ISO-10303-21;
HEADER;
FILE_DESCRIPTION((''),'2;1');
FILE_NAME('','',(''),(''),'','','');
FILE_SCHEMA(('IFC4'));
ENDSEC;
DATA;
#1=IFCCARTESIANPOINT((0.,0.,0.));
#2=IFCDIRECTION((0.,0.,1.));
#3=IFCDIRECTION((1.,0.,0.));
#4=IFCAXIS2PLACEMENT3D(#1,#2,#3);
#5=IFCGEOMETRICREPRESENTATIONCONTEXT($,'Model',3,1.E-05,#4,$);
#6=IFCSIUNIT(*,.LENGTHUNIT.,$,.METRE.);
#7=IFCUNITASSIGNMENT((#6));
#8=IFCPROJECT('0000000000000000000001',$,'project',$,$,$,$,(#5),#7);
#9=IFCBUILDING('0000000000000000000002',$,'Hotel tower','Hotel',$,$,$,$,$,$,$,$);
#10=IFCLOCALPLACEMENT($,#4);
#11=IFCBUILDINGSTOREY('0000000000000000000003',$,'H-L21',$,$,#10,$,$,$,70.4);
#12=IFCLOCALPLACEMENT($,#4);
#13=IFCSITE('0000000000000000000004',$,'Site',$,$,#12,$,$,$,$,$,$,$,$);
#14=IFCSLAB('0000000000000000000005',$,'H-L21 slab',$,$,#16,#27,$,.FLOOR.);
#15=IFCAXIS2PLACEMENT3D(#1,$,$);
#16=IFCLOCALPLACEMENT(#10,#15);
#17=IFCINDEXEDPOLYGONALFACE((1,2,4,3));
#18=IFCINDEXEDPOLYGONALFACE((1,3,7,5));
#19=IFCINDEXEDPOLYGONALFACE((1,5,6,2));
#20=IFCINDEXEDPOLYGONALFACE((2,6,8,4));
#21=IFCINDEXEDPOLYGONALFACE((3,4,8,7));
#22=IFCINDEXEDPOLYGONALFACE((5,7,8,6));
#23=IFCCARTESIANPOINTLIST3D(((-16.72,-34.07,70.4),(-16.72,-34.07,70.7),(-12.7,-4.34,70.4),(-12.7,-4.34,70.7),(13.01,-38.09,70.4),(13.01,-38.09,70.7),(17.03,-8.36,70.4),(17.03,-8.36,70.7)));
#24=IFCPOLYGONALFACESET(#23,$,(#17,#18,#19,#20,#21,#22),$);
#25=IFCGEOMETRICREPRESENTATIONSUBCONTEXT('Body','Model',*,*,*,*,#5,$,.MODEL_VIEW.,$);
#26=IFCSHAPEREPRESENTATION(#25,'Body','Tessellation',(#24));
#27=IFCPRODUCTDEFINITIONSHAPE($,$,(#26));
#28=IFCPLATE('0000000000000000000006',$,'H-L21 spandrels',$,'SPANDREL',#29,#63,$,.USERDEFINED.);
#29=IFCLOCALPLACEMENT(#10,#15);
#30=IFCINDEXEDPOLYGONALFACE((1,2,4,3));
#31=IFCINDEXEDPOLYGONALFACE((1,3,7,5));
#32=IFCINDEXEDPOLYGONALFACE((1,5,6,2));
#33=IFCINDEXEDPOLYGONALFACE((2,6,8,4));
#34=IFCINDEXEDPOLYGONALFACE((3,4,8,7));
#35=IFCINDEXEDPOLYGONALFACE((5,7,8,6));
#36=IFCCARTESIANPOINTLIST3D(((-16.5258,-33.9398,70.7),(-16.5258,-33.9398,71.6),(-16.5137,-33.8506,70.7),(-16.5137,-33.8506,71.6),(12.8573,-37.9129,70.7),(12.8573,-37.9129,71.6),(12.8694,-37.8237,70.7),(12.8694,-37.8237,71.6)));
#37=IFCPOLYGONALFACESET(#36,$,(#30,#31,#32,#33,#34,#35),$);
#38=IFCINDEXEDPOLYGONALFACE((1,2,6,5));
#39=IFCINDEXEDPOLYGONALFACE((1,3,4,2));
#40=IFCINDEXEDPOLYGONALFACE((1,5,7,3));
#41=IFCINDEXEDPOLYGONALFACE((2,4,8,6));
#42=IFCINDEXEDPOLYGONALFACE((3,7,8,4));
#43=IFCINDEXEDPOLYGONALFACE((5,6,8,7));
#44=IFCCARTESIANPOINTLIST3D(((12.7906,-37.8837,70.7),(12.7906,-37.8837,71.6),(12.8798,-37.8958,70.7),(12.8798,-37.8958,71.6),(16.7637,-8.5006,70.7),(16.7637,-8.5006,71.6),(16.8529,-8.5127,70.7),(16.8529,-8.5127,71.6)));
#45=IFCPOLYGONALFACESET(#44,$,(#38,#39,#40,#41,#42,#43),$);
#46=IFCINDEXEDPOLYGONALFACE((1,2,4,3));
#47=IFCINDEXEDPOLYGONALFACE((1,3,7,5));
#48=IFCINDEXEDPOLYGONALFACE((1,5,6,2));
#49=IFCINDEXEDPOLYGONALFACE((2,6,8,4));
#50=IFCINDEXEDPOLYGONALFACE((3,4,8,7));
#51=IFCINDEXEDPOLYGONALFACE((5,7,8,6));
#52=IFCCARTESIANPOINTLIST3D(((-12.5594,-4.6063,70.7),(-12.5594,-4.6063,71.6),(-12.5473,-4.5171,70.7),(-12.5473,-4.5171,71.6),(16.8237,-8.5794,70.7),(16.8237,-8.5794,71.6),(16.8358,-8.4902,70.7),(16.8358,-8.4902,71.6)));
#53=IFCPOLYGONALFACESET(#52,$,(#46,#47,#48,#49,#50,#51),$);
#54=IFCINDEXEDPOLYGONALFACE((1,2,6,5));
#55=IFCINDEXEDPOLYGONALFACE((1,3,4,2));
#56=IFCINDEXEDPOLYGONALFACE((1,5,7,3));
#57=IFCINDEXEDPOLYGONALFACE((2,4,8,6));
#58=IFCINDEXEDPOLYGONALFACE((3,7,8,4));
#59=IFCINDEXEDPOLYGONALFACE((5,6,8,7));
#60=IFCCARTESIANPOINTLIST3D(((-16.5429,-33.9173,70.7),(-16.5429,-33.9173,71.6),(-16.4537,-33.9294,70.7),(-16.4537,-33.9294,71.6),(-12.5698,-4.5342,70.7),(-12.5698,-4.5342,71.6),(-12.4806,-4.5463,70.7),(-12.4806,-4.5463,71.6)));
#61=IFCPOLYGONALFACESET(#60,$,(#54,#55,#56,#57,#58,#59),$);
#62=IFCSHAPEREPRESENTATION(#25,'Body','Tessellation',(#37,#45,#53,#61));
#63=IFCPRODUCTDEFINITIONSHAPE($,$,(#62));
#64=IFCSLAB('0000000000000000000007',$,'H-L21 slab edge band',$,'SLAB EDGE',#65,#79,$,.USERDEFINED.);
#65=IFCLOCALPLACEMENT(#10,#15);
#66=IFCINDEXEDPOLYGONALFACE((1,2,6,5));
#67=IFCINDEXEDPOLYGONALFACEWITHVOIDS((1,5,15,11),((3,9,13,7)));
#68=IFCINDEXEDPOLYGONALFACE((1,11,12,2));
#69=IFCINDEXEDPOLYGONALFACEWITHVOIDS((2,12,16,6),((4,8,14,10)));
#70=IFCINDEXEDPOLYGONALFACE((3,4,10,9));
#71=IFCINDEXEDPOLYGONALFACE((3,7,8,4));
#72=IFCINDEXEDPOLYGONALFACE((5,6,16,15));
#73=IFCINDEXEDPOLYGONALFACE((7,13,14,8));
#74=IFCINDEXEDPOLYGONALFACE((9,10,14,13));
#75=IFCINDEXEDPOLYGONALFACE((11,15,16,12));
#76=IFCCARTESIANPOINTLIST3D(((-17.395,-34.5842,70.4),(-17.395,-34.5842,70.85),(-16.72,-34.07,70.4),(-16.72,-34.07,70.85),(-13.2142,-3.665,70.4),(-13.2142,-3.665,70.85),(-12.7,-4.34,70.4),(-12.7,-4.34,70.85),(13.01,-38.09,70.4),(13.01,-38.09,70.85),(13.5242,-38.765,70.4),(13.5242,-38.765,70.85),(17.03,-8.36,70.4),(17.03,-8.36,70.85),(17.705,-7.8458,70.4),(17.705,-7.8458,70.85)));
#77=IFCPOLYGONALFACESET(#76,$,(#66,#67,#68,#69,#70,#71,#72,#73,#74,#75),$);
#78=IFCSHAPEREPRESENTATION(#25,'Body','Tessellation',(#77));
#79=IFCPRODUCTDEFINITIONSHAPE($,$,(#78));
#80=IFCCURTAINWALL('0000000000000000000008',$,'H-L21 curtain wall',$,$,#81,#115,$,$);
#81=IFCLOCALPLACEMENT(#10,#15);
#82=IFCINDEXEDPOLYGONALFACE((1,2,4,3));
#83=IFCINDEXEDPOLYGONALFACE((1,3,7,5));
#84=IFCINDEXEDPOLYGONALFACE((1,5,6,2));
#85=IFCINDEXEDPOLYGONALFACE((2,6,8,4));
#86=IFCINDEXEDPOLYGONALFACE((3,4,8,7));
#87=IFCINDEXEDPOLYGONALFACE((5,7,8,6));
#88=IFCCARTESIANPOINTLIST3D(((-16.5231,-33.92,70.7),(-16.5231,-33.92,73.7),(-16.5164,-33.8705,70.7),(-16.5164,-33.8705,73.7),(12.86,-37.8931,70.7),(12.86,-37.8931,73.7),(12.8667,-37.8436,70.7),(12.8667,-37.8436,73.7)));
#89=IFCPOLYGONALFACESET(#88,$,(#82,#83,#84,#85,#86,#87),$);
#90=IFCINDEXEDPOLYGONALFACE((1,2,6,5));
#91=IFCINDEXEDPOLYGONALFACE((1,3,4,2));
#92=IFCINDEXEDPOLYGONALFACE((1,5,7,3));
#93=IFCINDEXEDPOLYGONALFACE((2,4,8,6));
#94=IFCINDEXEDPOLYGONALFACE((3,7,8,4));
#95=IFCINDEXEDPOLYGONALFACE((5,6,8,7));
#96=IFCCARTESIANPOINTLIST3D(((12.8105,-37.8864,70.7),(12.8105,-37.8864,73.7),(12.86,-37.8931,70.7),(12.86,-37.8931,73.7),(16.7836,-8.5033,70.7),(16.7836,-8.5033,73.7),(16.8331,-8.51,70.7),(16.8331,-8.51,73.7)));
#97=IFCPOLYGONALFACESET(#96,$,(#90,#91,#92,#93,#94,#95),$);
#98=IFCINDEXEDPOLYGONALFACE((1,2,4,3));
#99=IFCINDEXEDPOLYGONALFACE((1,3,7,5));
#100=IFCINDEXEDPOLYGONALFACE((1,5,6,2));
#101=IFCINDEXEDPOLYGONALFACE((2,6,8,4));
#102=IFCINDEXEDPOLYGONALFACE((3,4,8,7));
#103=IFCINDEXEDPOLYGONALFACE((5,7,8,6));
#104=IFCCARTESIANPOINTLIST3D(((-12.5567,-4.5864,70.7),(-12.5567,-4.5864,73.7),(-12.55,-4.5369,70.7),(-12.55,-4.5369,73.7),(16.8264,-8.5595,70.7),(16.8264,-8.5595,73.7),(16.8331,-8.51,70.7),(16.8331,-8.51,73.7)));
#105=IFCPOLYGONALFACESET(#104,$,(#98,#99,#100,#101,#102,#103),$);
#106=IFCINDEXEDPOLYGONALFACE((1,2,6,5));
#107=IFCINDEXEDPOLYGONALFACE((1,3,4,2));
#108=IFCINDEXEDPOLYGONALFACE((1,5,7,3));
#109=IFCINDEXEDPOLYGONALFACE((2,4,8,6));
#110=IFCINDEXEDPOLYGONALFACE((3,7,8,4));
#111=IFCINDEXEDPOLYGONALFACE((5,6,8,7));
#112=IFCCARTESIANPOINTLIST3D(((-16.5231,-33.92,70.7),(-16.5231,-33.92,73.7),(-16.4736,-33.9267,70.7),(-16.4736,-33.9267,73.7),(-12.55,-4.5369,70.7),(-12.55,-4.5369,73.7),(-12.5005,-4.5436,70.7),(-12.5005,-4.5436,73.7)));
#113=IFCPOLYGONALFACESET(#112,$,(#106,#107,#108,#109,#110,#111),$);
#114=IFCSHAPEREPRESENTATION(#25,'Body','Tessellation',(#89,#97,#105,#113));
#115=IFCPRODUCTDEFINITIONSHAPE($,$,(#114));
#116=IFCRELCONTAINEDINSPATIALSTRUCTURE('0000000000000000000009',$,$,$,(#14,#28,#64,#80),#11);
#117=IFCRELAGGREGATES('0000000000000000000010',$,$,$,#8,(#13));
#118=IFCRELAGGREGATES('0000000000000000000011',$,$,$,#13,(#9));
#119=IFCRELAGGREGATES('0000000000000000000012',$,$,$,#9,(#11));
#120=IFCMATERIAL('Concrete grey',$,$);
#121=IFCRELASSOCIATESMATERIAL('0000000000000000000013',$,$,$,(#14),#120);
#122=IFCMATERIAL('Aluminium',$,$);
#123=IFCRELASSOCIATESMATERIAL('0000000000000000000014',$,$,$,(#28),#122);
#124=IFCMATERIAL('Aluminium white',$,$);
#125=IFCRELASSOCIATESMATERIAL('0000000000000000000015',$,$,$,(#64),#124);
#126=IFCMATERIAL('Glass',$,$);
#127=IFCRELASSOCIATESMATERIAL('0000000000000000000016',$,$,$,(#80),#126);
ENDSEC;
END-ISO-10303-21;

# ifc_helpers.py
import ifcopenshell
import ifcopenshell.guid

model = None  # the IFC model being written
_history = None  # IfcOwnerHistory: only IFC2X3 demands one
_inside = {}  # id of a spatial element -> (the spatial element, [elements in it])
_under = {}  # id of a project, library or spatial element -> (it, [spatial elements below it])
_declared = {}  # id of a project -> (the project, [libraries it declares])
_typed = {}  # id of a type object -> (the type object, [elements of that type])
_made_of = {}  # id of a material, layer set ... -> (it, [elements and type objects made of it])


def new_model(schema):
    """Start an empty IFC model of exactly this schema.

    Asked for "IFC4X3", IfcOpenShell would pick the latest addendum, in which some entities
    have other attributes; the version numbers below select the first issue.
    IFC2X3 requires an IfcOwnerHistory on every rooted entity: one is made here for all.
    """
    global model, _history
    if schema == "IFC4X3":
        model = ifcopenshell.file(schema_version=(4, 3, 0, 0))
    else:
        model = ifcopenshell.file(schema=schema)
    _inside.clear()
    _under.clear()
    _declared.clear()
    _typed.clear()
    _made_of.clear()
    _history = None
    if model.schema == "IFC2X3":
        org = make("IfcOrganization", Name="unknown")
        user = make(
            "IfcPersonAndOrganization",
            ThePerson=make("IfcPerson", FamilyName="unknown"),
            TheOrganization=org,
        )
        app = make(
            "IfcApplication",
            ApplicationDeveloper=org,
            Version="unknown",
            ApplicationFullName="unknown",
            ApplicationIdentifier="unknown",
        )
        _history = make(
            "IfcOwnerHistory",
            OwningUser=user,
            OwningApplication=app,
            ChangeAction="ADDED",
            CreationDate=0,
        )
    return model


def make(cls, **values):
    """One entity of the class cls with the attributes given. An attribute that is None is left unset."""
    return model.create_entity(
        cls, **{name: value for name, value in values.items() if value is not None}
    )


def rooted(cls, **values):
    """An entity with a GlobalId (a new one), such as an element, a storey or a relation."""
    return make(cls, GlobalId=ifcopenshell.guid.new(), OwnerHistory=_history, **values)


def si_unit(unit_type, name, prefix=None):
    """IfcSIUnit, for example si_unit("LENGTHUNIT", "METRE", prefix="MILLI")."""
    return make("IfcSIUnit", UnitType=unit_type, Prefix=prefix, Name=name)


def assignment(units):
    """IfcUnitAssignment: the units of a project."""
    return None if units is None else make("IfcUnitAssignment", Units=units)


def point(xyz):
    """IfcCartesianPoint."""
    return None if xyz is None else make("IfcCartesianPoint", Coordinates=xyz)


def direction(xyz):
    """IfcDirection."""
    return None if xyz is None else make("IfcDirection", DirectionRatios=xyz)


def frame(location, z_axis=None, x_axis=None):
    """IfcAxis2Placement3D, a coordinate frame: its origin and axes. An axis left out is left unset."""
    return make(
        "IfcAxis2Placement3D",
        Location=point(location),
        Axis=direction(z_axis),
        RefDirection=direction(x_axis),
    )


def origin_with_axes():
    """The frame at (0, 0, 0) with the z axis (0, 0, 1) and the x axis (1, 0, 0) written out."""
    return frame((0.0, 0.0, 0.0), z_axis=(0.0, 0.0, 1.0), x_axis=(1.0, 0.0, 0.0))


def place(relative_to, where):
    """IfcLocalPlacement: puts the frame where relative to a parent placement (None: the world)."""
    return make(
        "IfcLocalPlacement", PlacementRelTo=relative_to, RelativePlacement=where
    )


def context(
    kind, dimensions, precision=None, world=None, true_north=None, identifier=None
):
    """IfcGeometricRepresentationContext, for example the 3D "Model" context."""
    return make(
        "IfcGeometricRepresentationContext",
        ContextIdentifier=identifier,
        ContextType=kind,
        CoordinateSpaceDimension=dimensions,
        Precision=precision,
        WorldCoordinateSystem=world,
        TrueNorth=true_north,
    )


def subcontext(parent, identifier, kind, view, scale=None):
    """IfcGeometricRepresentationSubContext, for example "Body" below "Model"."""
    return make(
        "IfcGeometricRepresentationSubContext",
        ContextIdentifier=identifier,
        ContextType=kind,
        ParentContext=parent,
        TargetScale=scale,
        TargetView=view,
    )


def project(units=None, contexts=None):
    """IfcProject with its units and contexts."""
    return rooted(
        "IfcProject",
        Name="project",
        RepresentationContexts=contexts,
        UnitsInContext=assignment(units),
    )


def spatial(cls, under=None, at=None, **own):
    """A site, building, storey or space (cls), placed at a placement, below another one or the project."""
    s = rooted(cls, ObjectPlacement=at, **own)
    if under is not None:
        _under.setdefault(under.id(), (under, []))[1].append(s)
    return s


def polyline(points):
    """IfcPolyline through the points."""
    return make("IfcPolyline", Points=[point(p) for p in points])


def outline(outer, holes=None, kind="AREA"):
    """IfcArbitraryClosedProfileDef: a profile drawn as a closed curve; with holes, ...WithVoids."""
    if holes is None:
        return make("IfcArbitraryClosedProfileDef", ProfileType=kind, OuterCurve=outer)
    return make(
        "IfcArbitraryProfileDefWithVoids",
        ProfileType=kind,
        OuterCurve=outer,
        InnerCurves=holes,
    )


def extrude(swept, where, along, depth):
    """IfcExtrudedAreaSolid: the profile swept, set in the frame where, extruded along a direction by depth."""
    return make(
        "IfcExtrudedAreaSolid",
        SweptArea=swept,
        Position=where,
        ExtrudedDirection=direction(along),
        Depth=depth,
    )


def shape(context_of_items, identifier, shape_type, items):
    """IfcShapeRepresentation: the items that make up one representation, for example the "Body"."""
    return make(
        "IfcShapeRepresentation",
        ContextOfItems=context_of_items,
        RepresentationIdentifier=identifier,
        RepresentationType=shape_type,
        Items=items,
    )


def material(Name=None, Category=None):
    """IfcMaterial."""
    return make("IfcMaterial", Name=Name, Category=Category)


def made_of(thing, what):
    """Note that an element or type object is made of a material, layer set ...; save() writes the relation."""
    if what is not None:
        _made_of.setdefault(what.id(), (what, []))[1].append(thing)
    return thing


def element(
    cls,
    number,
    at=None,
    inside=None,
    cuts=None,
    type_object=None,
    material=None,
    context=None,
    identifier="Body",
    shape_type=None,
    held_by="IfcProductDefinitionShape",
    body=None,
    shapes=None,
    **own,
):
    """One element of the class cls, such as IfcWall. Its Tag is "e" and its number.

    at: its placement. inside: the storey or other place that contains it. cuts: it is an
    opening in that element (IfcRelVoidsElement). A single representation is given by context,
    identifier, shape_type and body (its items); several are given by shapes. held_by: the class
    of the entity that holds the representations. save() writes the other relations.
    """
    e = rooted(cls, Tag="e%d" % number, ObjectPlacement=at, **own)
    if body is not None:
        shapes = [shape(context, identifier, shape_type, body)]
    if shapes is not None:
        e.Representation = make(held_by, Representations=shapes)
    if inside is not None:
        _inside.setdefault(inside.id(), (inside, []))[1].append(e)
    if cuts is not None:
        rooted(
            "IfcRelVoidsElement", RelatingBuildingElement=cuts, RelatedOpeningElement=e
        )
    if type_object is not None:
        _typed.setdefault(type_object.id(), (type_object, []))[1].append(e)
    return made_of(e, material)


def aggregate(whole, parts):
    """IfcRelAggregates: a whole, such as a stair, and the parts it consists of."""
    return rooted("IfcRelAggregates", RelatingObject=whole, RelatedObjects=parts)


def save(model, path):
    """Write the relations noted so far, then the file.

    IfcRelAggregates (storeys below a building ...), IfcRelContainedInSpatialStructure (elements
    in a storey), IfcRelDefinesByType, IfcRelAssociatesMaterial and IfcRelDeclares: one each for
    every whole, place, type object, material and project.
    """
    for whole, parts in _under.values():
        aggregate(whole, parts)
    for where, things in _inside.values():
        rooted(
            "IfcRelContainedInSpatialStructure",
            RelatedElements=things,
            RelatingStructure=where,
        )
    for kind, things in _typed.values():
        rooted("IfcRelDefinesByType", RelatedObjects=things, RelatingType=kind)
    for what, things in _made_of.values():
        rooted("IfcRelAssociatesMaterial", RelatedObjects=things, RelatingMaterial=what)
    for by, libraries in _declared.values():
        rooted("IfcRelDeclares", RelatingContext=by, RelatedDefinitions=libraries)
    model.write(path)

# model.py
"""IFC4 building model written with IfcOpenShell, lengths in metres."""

from ifc_helpers import new_model, si_unit, frame, origin_with_axes, place, context, subcontext, project, spatial, polyline, outline, extrude, material, element, save


model = new_model("IFC4")

# Units and contexts
model_context = context("Model", 3, precision=1e-05, world=origin_with_axes())
body_context = subcontext(model_context, "Body", "Model", "MODEL_VIEW")
ifc_project = project(units=[si_unit("LENGTHUNIT", "METRE")], contexts=[model_context])

# Site, building, storey
site_placement = place(None, origin_with_axes())
site = spatial("IfcSite", under=ifc_project, at=site_placement, Name="Site")
building = spatial("IfcBuilding", under=site, Name="Hotel tower", Description="Hotel")
storey_placement = place(None, origin_with_axes())
storey = spatial("IfcBuildingStorey", under=building, at=storey_placement, Name="H-L21", Elevation=70.4)

# Shared definitions
ifc_material_1 = material(Name="Aluminium")

# Slab
ifc_material_2 = material(Name="Concrete grey")
slab_1_placement = place(storey_placement, origin_with_axes())
element("IfcSlab", 1, at=slab_1_placement, inside=storey, material=ifc_material_2, Name="H-L21 slab", PredefinedType="FLOOR", context=body_context, shape_type="SweptSolid", body=[
    extrude(outline(polyline([(-16.72, -34.07), (13.01, -38.09), (17.03, -8.36), (-12.7, -4.34), (-16.72, -34.07)])), frame((0.0, 0.0, 70.4), z_axis=(0.0, 0.0, 1.0), x_axis=(1.0, 0.0, 0.0)), (0.0, 0.0, 1.0), 0.3),
])

# Plate
plate_placement = place(storey_placement, origin_with_axes())
element("IfcPlate", 2, at=plate_placement, inside=storey, material=ifc_material_1, Name="H-L21 spandrels", ObjectType="SPANDREL", PredefinedType="USERDEFINED", context=body_context, shape_type="SweptSolid", body=[
    extrude(outline(polyline([(-16.5258, -33.9398), (12.8573, -37.9129), (12.8694, -37.8237), (-16.5137, -33.8506), (-16.5258, -33.9398)])), frame((0.0, 0.0, 70.7), z_axis=(0.0, 0.0, 1.0), x_axis=(1.0, 0.0, 0.0)), (0.0, 0.0, 1.0), 0.9),
    extrude(outline(polyline([(12.8798, -37.8958), (16.8529, -8.5127), (16.7637, -8.5006), (12.7906, -37.8837), (12.8798, -37.8958)])), frame((0.0, 0.0, 70.7), z_axis=(0.0, 0.0, 1.0), x_axis=(1.0, 0.0, 0.0)), (0.0, 0.0, 1.0), 0.9),
    extrude(outline(polyline([(16.8358, -8.4902), (-12.5473, -4.5171), (-12.5594, -4.6063), (16.8237, -8.5794), (16.8358, -8.4902)])), frame((0.0, 0.0, 70.7), z_axis=(0.0, 0.0, 1.0), x_axis=(1.0, 0.0, 0.0)), (0.0, 0.0, 1.0), 0.9),
    extrude(outline(polyline([(-12.5698, -4.5342), (-16.5429, -33.9173), (-16.4537, -33.9294), (-12.4806, -4.5463), (-12.5698, -4.5342)])), frame((0.0, 0.0, 70.7), z_axis=(0.0, 0.0, 1.0), x_axis=(1.0, 0.0, 0.0)), (0.0, 0.0, 1.0), 0.9),
])

# Slab
ifc_material_3 = material(Name="Aluminium white")
slab_2_placement = place(storey_placement, origin_with_axes())
element("IfcSlab", 3, at=slab_2_placement, inside=storey, material=ifc_material_3, Name="H-L21 slab edge band", ObjectType="SLAB EDGE", PredefinedType="USERDEFINED", context=body_context, shape_type="SweptSolid", body=[
    extrude(outline(polyline([(-17.395, -34.5842), (13.5242, -38.765), (17.705, -7.8458), (-13.2142, -3.665), (-17.395, -34.5842)]), holes=[polyline([(-16.72, -34.07), (13.01, -38.09), (17.03, -8.36), (-12.7, -4.34), (-16.72, -34.07)])]), frame((0.0, 0.0, 70.4), z_axis=(0.0, 0.0, 1.0), x_axis=(1.0, 0.0, 0.0)), (0.0, 0.0, 1.0), 0.45),
])

# Curtain wall
ifc_material_4 = material(Name="Glass")
curtain_wall_placement = place(storey_placement, origin_with_axes())
element("IfcCurtainWall", 4, at=curtain_wall_placement, inside=storey, material=ifc_material_4, Name="H-L21 curtain wall", context=body_context, shape_type="SweptSolid", body=[
    extrude(outline(polyline([(-16.5231, -33.92), (12.86, -37.8931), (12.8667, -37.8436), (-16.5164, -33.8705), (-16.5231, -33.92)])), frame((0.0, 0.0, 70.7), z_axis=(0.0, 0.0, 1.0), x_axis=(1.0, 0.0, 0.0)), (0.0, 0.0, 1.0), 3.0),
    extrude(outline(polyline([(12.86, -37.8931), (16.8331, -8.51), (16.7836, -8.5033), (12.8105, -37.8864), (12.86, -37.8931)])), frame((0.0, 0.0, 70.7), z_axis=(0.0, 0.0, 1.0), x_axis=(1.0, 0.0, 0.0)), (0.0, 0.0, 1.0), 3.0),
    extrude(outline(polyline([(16.8331, -8.51), (-12.55, -4.5369), (-12.5567, -4.5864), (16.8264, -8.5595), (16.8331, -8.51)])), frame((0.0, 0.0, 70.7), z_axis=(0.0, 0.0, 1.0), x_axis=(1.0, 0.0, 0.0)), (0.0, 0.0, 1.0), 3.0),
    extrude(outline(polyline([(-12.55, -4.5369), (-16.5231, -33.92), (-16.4736, -33.9267), (-12.5005, -4.5436), (-12.55, -4.5369)])), frame((0.0, 0.0, 70.7), z_axis=(0.0, 0.0, 1.0), x_axis=(1.0, 0.0, 0.0)), (0.0, 0.0, 1.0), 3.0),
])

save(model, "model.ifc")
